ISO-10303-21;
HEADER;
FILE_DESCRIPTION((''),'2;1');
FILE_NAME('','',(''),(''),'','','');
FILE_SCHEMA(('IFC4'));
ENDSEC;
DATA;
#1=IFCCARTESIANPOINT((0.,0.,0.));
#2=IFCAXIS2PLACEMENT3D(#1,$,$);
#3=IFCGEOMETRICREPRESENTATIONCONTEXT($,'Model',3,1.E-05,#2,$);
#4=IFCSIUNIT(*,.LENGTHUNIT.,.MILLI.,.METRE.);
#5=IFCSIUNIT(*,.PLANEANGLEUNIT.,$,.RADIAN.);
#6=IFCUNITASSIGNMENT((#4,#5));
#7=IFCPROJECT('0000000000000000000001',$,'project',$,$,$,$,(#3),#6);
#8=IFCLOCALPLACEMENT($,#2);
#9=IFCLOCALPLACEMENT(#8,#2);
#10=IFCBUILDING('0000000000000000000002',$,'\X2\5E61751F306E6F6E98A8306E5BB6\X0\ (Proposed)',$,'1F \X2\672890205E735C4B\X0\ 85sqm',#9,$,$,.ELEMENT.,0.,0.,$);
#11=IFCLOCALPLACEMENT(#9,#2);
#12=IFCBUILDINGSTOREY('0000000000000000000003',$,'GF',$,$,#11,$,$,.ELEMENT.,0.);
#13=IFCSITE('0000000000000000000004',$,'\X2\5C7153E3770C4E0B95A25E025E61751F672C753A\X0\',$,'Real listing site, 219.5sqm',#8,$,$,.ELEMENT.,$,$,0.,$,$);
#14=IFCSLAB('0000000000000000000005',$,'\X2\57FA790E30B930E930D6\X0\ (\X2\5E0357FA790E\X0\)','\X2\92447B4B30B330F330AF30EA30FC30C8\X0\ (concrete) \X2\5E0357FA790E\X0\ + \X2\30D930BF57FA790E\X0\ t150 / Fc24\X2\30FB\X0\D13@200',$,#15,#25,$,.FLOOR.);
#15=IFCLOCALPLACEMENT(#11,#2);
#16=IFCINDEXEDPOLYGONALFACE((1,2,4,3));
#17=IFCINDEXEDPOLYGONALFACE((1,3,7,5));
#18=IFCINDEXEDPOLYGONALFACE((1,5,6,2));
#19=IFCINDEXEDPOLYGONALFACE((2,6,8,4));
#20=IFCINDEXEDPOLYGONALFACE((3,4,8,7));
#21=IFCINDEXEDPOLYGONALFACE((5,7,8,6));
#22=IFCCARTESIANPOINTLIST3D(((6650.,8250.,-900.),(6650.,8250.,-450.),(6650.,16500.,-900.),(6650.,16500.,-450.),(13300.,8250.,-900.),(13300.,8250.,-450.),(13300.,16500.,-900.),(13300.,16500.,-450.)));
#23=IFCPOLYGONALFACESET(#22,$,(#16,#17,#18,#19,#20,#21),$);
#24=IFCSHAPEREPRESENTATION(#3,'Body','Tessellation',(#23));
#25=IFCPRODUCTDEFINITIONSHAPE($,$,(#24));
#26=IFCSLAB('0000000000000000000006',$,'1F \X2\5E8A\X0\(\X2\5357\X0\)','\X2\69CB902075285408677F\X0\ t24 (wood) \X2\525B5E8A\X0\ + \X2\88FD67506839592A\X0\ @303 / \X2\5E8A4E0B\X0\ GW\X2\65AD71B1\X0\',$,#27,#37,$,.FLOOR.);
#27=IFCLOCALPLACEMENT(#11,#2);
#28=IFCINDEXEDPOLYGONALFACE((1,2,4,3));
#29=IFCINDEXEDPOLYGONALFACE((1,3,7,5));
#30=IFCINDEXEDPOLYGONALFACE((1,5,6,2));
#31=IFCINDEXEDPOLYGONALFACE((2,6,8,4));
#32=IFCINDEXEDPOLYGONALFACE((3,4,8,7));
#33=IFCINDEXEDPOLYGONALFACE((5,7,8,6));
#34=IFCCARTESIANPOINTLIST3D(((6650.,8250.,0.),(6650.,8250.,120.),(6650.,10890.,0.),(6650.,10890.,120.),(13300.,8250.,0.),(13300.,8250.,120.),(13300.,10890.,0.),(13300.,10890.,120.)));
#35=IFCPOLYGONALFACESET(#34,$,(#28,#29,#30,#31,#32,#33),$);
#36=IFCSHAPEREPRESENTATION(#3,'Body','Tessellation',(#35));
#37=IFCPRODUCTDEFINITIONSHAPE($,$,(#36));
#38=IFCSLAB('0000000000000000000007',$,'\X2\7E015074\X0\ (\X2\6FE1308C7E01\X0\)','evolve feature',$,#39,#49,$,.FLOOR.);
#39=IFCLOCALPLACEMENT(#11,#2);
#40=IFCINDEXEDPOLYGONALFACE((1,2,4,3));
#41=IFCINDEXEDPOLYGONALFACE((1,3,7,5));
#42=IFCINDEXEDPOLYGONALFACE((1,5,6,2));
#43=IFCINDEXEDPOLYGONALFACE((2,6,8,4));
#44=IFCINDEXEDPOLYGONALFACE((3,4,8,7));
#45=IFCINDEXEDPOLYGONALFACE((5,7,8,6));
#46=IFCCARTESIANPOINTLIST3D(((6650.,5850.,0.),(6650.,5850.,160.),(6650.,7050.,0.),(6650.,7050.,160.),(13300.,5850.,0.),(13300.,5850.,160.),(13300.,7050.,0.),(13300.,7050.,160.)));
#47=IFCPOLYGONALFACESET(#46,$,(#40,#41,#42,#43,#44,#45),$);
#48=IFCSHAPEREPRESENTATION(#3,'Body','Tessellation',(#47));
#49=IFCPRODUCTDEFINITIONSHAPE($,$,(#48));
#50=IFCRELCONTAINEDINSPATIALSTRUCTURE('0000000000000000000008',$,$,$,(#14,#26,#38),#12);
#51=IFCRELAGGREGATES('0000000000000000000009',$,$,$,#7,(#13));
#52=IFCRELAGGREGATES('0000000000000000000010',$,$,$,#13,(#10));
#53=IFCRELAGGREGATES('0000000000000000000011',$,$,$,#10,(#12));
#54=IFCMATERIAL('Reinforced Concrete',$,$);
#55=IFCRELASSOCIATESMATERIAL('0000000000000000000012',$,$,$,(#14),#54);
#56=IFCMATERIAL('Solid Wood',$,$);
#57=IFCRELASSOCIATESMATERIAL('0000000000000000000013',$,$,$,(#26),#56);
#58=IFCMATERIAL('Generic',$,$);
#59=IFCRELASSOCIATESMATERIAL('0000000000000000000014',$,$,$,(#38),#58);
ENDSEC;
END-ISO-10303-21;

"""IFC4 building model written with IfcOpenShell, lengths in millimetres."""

from ifc_helpers import new_model, si_unit, frame, frame_2d, origin, place, context, project, spatial, rectangle, extrude, material, element, save


model = new_model("IFC4")

# Units and contexts
model_context = context("Model", 3, precision=1e-05, world=origin())
ifc_project = project(units=[si_unit("LENGTHUNIT", "METRE", prefix="MILLI"), si_unit("PLANEANGLEUNIT", "RADIAN")], contexts=[model_context])

# Site, building, storey
site_placement = place(None, origin())
site = spatial("IfcSite", under=ifc_project, at=site_placement, Name="山口県下関市幡生本町", ObjectType="Real listing site, 219.5sqm", CompositionType="ELEMENT", RefElevation=0.0)
building_placement = place(site_placement, origin())
building = spatial("IfcBuilding", under=site, at=building_placement, Name="幡生の潮風の家 (Proposed)", ObjectType="1F 木造平屋 85sqm", CompositionType="ELEMENT", ElevationOfRefHeight=0.0, ElevationOfTerrain=0.0)
storey_placement = place(building_placement, origin())
storey = spatial("IfcBuildingStorey", under=building, at=storey_placement, Name="GF", CompositionType="ELEMENT", Elevation=0.0)

# Slabs
ifc_material_1 = material(Name="Reinforced Concrete")
slab_1_placement = place(storey_placement, frame((3325.0, 4125.0, -450.0)))
element("IfcSlab", 1, at=slab_1_placement, inside=storey, material=ifc_material_1, Name="基礎スラブ (布基礎)", Description="鉄筋コンクリート (concrete) 布基礎 + ベタ基礎 t150 / Fc24・D13@200", PredefinedType="FLOOR", context=model_context, shape_type="SweptSolid", body=[
    extrude(rectangle(XDim=6650.0, YDim=8250.0, at=frame_2d((3325.0, 4125.0))), frame((3325.0, 4125.0, -450.0)), (0.0, 0.0, 1.0), 450.0),
])
ifc_material_2 = material(Name="Solid Wood")
slab_2_placement = place(storey_placement, frame((3325.0, 4125.0, 0.0)))
element("IfcSlab", 2, at=slab_2_placement, inside=storey, material=ifc_material_2, Name="1F 床(南)", Description="構造用合板 t24 (wood) 剛床 + 製材根太 @303 / 床下 GW断熱", PredefinedType="FLOOR", context=model_context, shape_type="SweptSolid", body=[
    extrude(rectangle(XDim=6650.0, YDim=2640.0, at=frame_2d((3325.0, 1320.0))), frame((3325.0, 4125.0, 0.0)), (0.0, 0.0, 1.0), 120.0),
])
ifc_material_3 = material(Name="Generic")
slab_3_placement = place(storey_placement, frame((3325.0, 2925.0, 0.0)))
element("IfcSlab", 3, at=slab_3_placement, inside=storey, material=ifc_material_3, Name="縁側 (濡れ縁)", Description="evolve feature", PredefinedType="FLOOR", context=model_context, shape_type="SweptSolid", body=[
    extrude(rectangle(XDim=6650.0, YDim=1200.0, at=frame_2d((3325.0, 600.0))), frame((3325.0, 2925.0, 0.0)), (0.0, 0.0, 1.0), 160.0),
])

save(model, "model.ifc")
